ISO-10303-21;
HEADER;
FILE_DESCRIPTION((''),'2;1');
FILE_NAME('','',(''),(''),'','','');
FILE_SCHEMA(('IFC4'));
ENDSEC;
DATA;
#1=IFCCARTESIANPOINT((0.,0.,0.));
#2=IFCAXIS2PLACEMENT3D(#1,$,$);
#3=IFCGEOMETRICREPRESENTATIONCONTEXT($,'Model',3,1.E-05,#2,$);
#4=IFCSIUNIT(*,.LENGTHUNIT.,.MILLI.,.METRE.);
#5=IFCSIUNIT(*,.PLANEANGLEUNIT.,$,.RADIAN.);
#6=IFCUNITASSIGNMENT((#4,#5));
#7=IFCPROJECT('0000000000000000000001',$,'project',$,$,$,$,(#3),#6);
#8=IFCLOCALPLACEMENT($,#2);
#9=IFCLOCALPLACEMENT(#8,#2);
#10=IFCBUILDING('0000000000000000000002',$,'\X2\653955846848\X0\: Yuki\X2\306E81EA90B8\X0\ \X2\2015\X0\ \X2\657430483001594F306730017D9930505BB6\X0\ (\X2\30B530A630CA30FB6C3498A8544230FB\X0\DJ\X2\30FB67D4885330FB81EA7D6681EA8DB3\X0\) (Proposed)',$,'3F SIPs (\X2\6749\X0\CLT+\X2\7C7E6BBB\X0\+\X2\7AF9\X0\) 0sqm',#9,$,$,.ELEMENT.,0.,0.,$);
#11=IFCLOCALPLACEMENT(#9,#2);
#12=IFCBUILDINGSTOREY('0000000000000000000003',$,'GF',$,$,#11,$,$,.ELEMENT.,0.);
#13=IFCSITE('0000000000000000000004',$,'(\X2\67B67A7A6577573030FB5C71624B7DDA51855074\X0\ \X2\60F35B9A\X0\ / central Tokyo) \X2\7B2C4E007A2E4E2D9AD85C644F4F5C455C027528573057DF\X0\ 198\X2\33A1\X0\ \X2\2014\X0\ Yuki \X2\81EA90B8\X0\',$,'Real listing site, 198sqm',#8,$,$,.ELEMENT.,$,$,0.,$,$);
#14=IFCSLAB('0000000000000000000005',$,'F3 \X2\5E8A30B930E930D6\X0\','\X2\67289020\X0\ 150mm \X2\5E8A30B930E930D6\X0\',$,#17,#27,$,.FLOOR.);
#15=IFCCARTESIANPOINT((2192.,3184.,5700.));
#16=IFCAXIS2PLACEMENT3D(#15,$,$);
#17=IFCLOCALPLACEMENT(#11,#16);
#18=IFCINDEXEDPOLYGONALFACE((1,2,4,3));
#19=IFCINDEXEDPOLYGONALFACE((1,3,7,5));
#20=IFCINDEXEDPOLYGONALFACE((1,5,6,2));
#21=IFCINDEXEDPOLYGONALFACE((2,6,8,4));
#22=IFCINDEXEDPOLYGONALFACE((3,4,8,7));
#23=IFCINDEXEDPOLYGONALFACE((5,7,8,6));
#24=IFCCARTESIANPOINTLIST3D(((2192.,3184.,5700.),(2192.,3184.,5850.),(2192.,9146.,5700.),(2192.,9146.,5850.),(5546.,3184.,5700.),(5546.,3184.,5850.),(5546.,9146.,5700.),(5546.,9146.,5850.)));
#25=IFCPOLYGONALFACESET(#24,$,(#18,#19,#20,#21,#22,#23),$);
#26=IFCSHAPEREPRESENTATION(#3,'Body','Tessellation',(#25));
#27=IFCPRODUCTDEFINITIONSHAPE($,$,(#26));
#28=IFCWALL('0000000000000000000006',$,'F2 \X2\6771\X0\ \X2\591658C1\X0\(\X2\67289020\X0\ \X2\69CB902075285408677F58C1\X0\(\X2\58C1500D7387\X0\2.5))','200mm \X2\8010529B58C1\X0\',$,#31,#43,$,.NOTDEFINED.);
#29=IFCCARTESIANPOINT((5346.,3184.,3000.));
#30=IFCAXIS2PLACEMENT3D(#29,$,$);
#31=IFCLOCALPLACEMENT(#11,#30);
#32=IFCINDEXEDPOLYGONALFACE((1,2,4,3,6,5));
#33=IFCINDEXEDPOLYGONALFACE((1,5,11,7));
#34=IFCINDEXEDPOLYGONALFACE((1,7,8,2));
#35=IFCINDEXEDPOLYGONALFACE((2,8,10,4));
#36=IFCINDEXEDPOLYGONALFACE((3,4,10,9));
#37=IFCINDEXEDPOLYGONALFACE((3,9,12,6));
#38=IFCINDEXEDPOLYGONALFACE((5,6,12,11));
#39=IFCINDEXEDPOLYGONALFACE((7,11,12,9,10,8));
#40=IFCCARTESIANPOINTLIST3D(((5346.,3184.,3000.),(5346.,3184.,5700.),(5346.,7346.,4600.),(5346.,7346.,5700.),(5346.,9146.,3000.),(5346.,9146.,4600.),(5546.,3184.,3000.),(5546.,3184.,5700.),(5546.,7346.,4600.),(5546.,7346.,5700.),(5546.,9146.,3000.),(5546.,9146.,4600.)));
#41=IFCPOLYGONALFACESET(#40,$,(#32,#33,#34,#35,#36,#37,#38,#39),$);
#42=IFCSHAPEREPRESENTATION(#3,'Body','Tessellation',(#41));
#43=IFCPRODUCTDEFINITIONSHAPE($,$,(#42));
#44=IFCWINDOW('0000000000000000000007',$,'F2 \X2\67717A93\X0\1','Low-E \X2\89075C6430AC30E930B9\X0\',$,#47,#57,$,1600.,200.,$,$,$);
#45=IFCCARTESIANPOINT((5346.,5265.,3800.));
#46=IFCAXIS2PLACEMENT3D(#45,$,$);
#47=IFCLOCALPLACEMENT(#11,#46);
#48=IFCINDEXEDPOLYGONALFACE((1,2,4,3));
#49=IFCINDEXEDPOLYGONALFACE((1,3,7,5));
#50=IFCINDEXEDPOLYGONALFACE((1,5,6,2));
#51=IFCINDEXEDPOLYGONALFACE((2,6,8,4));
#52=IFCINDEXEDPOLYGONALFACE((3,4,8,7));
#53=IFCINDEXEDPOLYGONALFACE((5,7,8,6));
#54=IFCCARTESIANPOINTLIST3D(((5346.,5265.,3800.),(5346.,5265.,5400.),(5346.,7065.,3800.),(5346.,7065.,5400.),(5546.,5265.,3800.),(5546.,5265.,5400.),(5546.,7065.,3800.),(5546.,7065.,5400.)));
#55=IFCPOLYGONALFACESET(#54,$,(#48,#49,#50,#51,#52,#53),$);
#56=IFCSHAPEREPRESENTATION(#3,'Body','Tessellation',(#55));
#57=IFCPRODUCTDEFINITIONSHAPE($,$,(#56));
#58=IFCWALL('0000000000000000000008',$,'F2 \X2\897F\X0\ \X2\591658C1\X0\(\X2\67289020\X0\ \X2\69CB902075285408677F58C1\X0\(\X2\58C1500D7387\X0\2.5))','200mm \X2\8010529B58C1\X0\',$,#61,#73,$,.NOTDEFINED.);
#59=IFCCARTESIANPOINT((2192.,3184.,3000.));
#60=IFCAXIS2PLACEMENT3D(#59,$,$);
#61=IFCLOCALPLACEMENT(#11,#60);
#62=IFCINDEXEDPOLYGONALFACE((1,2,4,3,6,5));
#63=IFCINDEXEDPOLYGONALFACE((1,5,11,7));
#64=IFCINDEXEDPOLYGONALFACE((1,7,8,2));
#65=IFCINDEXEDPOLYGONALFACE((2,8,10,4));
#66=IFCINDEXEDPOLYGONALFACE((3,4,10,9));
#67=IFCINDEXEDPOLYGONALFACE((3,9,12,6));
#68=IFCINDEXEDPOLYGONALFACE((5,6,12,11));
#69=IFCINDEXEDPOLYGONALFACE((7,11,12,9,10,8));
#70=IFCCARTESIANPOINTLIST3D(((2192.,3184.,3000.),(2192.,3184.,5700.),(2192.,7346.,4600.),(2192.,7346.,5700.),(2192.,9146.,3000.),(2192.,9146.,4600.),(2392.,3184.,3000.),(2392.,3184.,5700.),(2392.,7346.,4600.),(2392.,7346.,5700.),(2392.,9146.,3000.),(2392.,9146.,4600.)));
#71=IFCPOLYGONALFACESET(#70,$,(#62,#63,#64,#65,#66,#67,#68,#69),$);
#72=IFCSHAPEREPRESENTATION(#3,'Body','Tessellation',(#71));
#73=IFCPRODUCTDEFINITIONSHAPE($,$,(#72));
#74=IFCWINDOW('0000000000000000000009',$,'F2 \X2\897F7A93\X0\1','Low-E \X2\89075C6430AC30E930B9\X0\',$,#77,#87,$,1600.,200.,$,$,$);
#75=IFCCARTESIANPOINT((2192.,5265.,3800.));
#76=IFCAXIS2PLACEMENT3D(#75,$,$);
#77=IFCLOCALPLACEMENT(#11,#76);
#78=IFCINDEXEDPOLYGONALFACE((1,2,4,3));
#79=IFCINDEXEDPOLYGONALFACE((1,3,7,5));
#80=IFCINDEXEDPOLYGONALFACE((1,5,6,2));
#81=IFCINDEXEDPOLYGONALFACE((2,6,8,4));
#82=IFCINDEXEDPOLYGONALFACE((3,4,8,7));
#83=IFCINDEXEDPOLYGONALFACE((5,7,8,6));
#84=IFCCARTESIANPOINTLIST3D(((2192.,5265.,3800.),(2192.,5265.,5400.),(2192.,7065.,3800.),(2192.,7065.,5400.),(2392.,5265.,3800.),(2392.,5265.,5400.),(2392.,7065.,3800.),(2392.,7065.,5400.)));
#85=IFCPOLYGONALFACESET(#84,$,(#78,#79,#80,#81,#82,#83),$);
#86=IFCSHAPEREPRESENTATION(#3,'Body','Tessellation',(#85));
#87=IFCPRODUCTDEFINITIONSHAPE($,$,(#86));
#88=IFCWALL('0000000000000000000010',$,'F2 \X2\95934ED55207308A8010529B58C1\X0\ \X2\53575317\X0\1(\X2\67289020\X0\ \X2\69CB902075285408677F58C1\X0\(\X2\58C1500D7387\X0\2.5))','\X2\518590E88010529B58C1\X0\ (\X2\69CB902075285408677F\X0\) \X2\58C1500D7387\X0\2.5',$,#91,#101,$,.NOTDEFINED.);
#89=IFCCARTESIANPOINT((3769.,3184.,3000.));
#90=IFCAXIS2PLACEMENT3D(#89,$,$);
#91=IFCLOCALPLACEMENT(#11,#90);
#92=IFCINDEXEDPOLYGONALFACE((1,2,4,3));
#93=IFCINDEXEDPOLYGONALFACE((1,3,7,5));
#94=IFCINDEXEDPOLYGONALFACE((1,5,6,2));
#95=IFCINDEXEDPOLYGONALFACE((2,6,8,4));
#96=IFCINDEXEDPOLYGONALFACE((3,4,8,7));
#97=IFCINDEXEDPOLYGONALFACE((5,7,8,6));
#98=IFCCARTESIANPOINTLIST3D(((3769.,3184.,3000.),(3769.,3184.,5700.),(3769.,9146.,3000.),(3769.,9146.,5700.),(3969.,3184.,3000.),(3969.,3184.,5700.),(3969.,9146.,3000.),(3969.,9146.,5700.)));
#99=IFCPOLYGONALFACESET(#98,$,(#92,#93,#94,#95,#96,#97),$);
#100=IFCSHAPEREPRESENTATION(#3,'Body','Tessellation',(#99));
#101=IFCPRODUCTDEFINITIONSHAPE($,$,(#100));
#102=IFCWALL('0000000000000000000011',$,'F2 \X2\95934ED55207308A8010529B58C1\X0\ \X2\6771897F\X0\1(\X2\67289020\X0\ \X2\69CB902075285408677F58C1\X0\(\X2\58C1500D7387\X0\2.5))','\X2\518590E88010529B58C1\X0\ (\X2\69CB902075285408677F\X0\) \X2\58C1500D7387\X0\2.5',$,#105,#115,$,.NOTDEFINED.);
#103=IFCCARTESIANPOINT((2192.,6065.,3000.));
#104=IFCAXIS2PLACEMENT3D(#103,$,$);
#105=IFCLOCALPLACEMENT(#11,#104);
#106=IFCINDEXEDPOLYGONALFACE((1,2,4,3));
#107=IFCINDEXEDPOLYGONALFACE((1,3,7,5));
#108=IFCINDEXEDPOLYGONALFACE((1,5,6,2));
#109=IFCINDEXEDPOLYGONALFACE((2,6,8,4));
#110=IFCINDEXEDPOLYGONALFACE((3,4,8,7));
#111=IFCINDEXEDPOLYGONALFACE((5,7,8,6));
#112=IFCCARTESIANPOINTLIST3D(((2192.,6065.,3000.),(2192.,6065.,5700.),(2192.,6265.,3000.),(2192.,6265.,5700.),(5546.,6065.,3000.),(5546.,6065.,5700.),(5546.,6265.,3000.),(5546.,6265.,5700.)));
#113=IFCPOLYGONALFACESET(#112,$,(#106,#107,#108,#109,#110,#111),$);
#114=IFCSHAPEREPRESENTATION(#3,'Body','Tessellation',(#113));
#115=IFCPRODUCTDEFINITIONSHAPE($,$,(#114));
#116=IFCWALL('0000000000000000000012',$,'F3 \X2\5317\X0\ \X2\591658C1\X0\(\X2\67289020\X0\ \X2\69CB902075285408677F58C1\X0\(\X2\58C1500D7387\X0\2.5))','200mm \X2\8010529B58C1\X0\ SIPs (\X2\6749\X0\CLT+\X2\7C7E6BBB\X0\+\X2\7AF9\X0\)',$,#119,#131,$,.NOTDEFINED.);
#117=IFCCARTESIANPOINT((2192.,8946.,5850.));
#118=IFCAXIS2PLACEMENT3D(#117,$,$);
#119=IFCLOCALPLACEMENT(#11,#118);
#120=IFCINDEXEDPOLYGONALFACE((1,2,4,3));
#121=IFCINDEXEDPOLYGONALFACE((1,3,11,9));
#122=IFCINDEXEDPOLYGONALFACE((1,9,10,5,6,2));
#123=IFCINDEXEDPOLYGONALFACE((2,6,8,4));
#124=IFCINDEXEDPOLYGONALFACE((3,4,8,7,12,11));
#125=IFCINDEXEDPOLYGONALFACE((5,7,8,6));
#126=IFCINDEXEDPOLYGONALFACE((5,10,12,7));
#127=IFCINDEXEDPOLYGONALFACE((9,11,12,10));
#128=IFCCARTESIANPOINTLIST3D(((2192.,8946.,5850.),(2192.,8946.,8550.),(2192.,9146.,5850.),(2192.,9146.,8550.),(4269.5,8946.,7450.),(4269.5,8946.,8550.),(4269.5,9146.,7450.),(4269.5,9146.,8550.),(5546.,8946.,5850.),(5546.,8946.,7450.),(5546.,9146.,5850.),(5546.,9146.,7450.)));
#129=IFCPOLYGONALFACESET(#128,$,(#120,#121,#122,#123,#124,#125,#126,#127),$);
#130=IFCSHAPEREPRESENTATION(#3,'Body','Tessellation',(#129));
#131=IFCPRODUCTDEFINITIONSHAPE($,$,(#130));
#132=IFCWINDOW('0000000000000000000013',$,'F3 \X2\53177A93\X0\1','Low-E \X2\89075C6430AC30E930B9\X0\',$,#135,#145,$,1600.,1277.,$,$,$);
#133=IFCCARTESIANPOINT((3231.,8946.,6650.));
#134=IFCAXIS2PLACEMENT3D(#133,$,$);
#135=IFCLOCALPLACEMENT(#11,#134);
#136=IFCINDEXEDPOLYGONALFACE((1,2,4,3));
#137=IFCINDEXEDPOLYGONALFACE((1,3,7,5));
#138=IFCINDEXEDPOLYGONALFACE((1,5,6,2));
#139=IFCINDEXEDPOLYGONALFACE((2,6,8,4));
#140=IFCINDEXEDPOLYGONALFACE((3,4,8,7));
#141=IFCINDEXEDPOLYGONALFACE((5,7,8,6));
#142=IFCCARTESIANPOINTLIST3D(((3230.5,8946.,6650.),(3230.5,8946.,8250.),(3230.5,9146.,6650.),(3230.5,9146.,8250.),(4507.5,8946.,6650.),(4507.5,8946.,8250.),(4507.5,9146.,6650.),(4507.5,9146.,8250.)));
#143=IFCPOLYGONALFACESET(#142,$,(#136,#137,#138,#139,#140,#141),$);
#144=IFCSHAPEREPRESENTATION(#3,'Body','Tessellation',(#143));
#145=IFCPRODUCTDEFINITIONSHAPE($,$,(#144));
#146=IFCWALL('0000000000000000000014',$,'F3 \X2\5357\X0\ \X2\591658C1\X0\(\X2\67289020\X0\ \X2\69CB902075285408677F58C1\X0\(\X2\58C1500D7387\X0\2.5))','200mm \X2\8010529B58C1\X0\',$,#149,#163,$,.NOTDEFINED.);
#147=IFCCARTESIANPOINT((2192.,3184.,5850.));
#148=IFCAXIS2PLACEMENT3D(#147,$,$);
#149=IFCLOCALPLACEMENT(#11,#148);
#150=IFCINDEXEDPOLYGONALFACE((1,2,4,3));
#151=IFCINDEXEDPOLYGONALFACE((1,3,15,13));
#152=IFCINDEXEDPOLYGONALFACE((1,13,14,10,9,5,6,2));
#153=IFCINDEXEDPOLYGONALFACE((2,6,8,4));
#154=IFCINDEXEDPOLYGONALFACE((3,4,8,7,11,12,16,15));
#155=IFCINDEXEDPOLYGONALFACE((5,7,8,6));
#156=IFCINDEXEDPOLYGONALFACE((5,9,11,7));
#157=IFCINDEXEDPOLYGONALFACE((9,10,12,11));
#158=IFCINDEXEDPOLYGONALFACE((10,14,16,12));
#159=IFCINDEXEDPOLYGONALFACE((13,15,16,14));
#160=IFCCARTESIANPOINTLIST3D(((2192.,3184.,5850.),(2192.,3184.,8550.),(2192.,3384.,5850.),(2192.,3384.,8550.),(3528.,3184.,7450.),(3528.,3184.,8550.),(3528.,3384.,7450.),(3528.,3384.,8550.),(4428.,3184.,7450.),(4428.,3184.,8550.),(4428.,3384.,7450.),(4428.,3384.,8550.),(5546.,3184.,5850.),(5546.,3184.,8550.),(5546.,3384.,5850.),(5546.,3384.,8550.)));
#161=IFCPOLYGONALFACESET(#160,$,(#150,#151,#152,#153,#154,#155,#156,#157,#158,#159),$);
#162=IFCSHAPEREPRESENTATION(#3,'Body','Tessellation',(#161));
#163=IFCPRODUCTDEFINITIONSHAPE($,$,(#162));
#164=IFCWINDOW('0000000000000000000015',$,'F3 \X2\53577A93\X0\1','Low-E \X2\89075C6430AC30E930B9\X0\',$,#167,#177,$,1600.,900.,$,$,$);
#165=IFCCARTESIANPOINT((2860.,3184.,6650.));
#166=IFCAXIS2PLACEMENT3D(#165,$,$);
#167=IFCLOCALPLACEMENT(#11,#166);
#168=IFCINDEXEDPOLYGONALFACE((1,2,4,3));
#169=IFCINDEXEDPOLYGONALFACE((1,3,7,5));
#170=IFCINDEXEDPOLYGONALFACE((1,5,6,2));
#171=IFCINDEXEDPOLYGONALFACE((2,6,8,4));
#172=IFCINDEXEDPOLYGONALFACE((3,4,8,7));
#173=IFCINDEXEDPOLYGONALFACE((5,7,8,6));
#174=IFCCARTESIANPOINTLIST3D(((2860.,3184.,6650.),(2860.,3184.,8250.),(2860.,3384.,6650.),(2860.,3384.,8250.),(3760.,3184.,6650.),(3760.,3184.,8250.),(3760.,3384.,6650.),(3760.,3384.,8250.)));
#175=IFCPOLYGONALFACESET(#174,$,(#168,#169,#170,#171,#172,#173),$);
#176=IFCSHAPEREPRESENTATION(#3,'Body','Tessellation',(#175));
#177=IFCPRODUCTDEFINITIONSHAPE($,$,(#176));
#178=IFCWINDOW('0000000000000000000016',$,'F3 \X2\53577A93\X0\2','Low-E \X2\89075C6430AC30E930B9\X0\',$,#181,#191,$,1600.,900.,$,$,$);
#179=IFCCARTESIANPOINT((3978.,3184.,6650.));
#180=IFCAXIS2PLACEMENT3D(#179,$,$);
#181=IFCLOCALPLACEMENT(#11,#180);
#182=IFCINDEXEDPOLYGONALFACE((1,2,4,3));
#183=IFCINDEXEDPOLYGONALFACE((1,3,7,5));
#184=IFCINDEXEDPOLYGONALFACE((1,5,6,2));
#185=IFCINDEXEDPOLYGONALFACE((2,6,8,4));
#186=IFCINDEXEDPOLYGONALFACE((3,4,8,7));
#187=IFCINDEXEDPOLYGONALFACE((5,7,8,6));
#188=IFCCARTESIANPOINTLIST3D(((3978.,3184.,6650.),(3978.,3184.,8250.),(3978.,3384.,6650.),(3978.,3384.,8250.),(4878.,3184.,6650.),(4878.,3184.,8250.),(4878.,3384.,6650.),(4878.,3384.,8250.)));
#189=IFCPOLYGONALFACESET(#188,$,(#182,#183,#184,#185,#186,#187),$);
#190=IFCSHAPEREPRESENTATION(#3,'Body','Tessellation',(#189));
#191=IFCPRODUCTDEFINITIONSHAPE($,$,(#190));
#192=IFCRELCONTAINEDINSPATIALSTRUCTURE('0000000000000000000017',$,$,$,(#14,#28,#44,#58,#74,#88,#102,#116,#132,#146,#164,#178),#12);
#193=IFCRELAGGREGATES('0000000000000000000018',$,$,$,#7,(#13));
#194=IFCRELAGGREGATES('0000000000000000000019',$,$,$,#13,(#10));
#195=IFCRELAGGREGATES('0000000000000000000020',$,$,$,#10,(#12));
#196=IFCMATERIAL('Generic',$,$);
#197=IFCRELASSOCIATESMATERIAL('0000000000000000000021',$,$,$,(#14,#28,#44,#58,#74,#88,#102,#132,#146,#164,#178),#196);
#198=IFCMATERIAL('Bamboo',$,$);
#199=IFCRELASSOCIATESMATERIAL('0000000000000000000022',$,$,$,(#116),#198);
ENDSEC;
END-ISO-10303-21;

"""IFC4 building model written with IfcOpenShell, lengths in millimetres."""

from ifc_helpers import new_model, si_unit, frame, frame_2d, origin, place, context, project, spatial, rectangle, extrude, material, element, fill, save


model = new_model("IFC4")

# Units and contexts
model_context = context("Model", 3, precision=1e-05, world=origin())
ifc_project = project(units=[si_unit("LENGTHUNIT", "METRE", prefix="MILLI"), si_unit("PLANEANGLEUNIT", "RADIAN")], contexts=[model_context])

# Site, building, storey
site_placement = place(None, origin())
site = spatial("IfcSite", under=ifc_project, at=site_placement, Name="(架空敷地・山手線内側 想定 / central Tokyo) 第一種中高層住居専用地域 198㎡ — Yuki 自邸", ObjectType="Real listing site, 198sqm", CompositionType="ELEMENT", RefElevation=0.0)
building_placement = place(site_placement, origin())
building = spatial("IfcBuilding", under=site, at=building_placement, Name="改善案: Yukiの自邸 ― 整え、奏で、継ぐ家 (サウナ・水風呂・DJ・柔術・自給自足) (Proposed)", ObjectType="3F SIPs (杉CLT+籾殻+竹) 0sqm", CompositionType="ELEMENT", ElevationOfRefHeight=0.0, ElevationOfTerrain=0.0)
storey_placement = place(building_placement, origin())
storey = spatial("IfcBuildingStorey", under=building, at=storey_placement, Name="GF", CompositionType="ELEMENT", Elevation=0.0)

# Slab
ifc_material_1 = material(Name="Generic")
slab_placement = place(storey_placement, frame((2192.0, 3184.0, 5700.0)))
element("IfcSlab", 1, at=slab_placement, inside=storey, material=ifc_material_1, Name="F3 床スラブ", Description="木造 150mm 床スラブ", PredefinedType="FLOOR", context=model_context, shape_type="SweptSolid", body=[
    extrude(rectangle(XDim=3354.0, YDim=5962.0, at=frame_2d((1677.0, 2981.0))), frame((2192.0, 3184.0, 5700.0)), (0.0, 0.0, 1.0), 150.0),
])

# Walls, openings, windows
wall_1_placement = place(storey_placement, frame((5346.0, 3184.0, 3000.0)))
wall_1 = element("IfcWall", 2, at=wall_1_placement, inside=storey, material=ifc_material_1, Name="F2 東 外壁(木造 構造用合板壁(壁倍率2.5))", Description="200mm 耐力壁", PredefinedType="NOTDEFINED", context=model_context, shape_type="SweptSolid", body=[
    extrude(rectangle(XDim=200.0, YDim=5962.0, at=frame_2d((100.0, 2981.0))), frame((5346.0, 3184.0, 3000.0)), (0.0, 0.0, 1.0), 2700.0),
])
opening_1_placement = place(storey_placement, frame((5346.0, 5265.0, 3800.0)))
opening_1 = element("IfcOpeningElement", 3, at=opening_1_placement, cuts=wall_1, PredefinedType="NOTDEFINED", context=model_context, shape_type="SweptSolid", body=[
    extrude(rectangle(XDim=200.0, YDim=1800.0, at=frame_2d((100.0, 900.0))), frame((5346.0, 5265.0, 3800.0)), (0.0, 0.0, 1.0), 1600.0),
])
window_1_placement = place(storey_placement, frame((5346.0, 5265.0, 3800.0)))
window_1 = element("IfcWindow", 4, at=window_1_placement, inside=storey, material=ifc_material_1, Name="F2 東窓1", Description="Low-E 複層ガラス", OverallHeight=1600.0, OverallWidth=200.0, context=model_context, shape_type="SweptSolid", body=[
    extrude(rectangle(XDim=200.0, YDim=1800.0, at=frame_2d((100.0, 900.0))), frame((5346.0, 5265.0, 3800.0)), (0.0, 0.0, 1.0), 1600.0),
])
fill(opening_1, window_1)
wall_2_placement = place(storey_placement, frame((2192.0, 3184.0, 3000.0)))
wall_2 = element("IfcWall", 5, at=wall_2_placement, inside=storey, material=ifc_material_1, Name="F2 西 外壁(木造 構造用合板壁(壁倍率2.5))", Description="200mm 耐力壁", PredefinedType="NOTDEFINED", context=model_context, shape_type="SweptSolid", body=[
    extrude(rectangle(XDim=200.0, YDim=5962.0, at=frame_2d((100.0, 2981.0))), frame((2192.0, 3184.0, 3000.0)), (0.0, 0.0, 1.0), 2700.0),
])
opening_2_placement = place(storey_placement, frame((2192.0, 5265.0, 3800.0)))
opening_2 = element("IfcOpeningElement", 6, at=opening_2_placement, cuts=wall_2, PredefinedType="NOTDEFINED", context=model_context, shape_type="SweptSolid", body=[
    extrude(rectangle(XDim=200.0, YDim=1800.0, at=frame_2d((100.0, 900.0))), frame((2192.0, 5265.0, 3800.0)), (0.0, 0.0, 1.0), 1600.0),
])
window_2_placement = place(storey_placement, frame((2192.0, 5265.0, 3800.0)))
window_2 = element("IfcWindow", 7, at=window_2_placement, inside=storey, material=ifc_material_1, Name="F2 西窓1", Description="Low-E 複層ガラス", OverallHeight=1600.0, OverallWidth=200.0, context=model_context, shape_type="SweptSolid", body=[
    extrude(rectangle(XDim=200.0, YDim=1800.0, at=frame_2d((100.0, 900.0))), frame((2192.0, 5265.0, 3800.0)), (0.0, 0.0, 1.0), 1600.0),
])
fill(opening_2, window_2)

# Walls
wall_3_placement = place(storey_placement, frame((3769.0, 3184.0, 3000.0)))
element("IfcWall", 8, at=wall_3_placement, inside=storey, material=ifc_material_1, Name="F2 間仕切り耐力壁 南北1(木造 構造用合板壁(壁倍率2.5))", Description="内部耐力壁 (構造用合板) 壁倍率2.5", PredefinedType="NOTDEFINED", context=model_context, shape_type="SweptSolid", body=[
    extrude(rectangle(XDim=200.0, YDim=5962.0, at=frame_2d((100.0, 2981.0))), frame((3769.0, 3184.0, 3000.0)), (0.0, 0.0, 1.0), 2700.0),
])
wall_4_placement = place(storey_placement, frame((2192.0, 6065.0, 3000.0)))
element("IfcWall", 9, at=wall_4_placement, inside=storey, material=ifc_material_1, Name="F2 間仕切り耐力壁 東西1(木造 構造用合板壁(壁倍率2.5))", Description="内部耐力壁 (構造用合板) 壁倍率2.5", PredefinedType="NOTDEFINED", context=model_context, shape_type="SweptSolid", body=[
    extrude(rectangle(XDim=3354.0, YDim=200.0, at=frame_2d((1677.0, 100.0))), frame((2192.0, 6065.0, 3000.0)), (0.0, 0.0, 1.0), 2700.0),
])

# Wall, opening, window
ifc_material_2 = material(Name="Bamboo")
wall_5_placement = place(storey_placement, frame((2192.0, 8946.0, 5850.0)))
wall_5 = element("IfcWall", 10, at=wall_5_placement, inside=storey, material=ifc_material_2, Name="F3 北 外壁(木造 構造用合板壁(壁倍率2.5))", Description="200mm 耐力壁 SIPs (杉CLT+籾殻+竹)", PredefinedType="NOTDEFINED", context=model_context, shape_type="SweptSolid", body=[
    extrude(rectangle(XDim=3354.0, YDim=200.0, at=frame_2d((1677.0, 100.0))), frame((2192.0, 8946.0, 5850.0)), (0.0, 0.0, 1.0), 2700.0),
])
opening_3_placement = place(storey_placement, frame((3231.0, 8946.0, 6650.0)))
opening_3 = element("IfcOpeningElement", 11, at=opening_3_placement, cuts=wall_5, PredefinedType="NOTDEFINED", context=model_context, shape_type="SweptSolid", body=[
    extrude(rectangle(XDim=1277.0, YDim=200.0, at=frame_2d((638.0, 100.0))), frame((3231.0, 8946.0, 6650.0)), (0.0, 0.0, 1.0), 1600.0),
])
window_3_placement = place(storey_placement, frame((3231.0, 8946.0, 6650.0)))
window_3 = element("IfcWindow", 12, at=window_3_placement, inside=storey, material=ifc_material_1, Name="F3 北窓1", Description="Low-E 複層ガラス", OverallHeight=1600.0, OverallWidth=1277.0, context=model_context, shape_type="SweptSolid", body=[
    extrude(rectangle(XDim=1277.0, YDim=200.0, at=frame_2d((638.0, 100.0))), frame((3231.0, 8946.0, 6650.0)), (0.0, 0.0, 1.0), 1600.0),
])
fill(opening_3, window_3)

# Wall, openings, windows
wall_6_placement = place(storey_placement, frame((2192.0, 3184.0, 5850.0)))
wall_6 = element("IfcWall", 13, at=wall_6_placement, inside=storey, material=ifc_material_1, Name="F3 南 外壁(木造 構造用合板壁(壁倍率2.5))", Description="200mm 耐力壁", PredefinedType="NOTDEFINED", context=model_context, shape_type="SweptSolid", body=[
    extrude(rectangle(XDim=3354.0, YDim=200.0, at=frame_2d((1677.0, 100.0))), frame((2192.0, 3184.0, 5850.0)), (0.0, 0.0, 1.0), 2700.0),
])
opening_4_placement = place(storey_placement, frame((2860.0, 3184.0, 6650.0)))
opening_4 = element("IfcOpeningElement", 14, at=opening_4_placement, cuts=wall_6, PredefinedType="NOTDEFINED", context=model_context, shape_type="SweptSolid", body=[
    extrude(rectangle(XDim=900.0, YDim=200.0, at=frame_2d((450.0, 100.0))), frame((2860.0, 3184.0, 6650.0)), (0.0, 0.0, 1.0), 1600.0),
])
opening_5_placement = place(storey_placement, frame((3978.0, 3184.0, 6650.0)))
opening_5 = element("IfcOpeningElement", 15, at=opening_5_placement, cuts=wall_6, PredefinedType="NOTDEFINED", context=model_context, shape_type="SweptSolid", body=[
    extrude(rectangle(XDim=900.0, YDim=200.0, at=frame_2d((450.0, 100.0))), frame((3978.0, 3184.0, 6650.0)), (0.0, 0.0, 1.0), 1600.0),
])
window_4_placement = place(storey_placement, frame((2860.0, 3184.0, 6650.0)))
window_4 = element("IfcWindow", 16, at=window_4_placement, inside=storey, material=ifc_material_1, Name="F3 南窓1", Description="Low-E 複層ガラス", OverallHeight=1600.0, OverallWidth=900.0, context=model_context, shape_type="SweptSolid", body=[
    extrude(rectangle(XDim=900.0, YDim=200.0, at=frame_2d((450.0, 100.0))), frame((2860.0, 3184.0, 6650.0)), (0.0, 0.0, 1.0), 1600.0),
])
fill(opening_4, window_4)
window_5_placement = place(storey_placement, frame((3978.0, 3184.0, 6650.0)))
window_5 = element("IfcWindow", 17, at=window_5_placement, inside=storey, material=ifc_material_1, Name="F3 南窓2", Description="Low-E 複層ガラス", OverallHeight=1600.0, OverallWidth=900.0, context=model_context, shape_type="SweptSolid", body=[
    extrude(rectangle(XDim=900.0, YDim=200.0, at=frame_2d((450.0, 100.0))), frame((3978.0, 3184.0, 6650.0)), (0.0, 0.0, 1.0), 1600.0),
])
fill(opening_5, window_5)

save(model, "model.ifc")
